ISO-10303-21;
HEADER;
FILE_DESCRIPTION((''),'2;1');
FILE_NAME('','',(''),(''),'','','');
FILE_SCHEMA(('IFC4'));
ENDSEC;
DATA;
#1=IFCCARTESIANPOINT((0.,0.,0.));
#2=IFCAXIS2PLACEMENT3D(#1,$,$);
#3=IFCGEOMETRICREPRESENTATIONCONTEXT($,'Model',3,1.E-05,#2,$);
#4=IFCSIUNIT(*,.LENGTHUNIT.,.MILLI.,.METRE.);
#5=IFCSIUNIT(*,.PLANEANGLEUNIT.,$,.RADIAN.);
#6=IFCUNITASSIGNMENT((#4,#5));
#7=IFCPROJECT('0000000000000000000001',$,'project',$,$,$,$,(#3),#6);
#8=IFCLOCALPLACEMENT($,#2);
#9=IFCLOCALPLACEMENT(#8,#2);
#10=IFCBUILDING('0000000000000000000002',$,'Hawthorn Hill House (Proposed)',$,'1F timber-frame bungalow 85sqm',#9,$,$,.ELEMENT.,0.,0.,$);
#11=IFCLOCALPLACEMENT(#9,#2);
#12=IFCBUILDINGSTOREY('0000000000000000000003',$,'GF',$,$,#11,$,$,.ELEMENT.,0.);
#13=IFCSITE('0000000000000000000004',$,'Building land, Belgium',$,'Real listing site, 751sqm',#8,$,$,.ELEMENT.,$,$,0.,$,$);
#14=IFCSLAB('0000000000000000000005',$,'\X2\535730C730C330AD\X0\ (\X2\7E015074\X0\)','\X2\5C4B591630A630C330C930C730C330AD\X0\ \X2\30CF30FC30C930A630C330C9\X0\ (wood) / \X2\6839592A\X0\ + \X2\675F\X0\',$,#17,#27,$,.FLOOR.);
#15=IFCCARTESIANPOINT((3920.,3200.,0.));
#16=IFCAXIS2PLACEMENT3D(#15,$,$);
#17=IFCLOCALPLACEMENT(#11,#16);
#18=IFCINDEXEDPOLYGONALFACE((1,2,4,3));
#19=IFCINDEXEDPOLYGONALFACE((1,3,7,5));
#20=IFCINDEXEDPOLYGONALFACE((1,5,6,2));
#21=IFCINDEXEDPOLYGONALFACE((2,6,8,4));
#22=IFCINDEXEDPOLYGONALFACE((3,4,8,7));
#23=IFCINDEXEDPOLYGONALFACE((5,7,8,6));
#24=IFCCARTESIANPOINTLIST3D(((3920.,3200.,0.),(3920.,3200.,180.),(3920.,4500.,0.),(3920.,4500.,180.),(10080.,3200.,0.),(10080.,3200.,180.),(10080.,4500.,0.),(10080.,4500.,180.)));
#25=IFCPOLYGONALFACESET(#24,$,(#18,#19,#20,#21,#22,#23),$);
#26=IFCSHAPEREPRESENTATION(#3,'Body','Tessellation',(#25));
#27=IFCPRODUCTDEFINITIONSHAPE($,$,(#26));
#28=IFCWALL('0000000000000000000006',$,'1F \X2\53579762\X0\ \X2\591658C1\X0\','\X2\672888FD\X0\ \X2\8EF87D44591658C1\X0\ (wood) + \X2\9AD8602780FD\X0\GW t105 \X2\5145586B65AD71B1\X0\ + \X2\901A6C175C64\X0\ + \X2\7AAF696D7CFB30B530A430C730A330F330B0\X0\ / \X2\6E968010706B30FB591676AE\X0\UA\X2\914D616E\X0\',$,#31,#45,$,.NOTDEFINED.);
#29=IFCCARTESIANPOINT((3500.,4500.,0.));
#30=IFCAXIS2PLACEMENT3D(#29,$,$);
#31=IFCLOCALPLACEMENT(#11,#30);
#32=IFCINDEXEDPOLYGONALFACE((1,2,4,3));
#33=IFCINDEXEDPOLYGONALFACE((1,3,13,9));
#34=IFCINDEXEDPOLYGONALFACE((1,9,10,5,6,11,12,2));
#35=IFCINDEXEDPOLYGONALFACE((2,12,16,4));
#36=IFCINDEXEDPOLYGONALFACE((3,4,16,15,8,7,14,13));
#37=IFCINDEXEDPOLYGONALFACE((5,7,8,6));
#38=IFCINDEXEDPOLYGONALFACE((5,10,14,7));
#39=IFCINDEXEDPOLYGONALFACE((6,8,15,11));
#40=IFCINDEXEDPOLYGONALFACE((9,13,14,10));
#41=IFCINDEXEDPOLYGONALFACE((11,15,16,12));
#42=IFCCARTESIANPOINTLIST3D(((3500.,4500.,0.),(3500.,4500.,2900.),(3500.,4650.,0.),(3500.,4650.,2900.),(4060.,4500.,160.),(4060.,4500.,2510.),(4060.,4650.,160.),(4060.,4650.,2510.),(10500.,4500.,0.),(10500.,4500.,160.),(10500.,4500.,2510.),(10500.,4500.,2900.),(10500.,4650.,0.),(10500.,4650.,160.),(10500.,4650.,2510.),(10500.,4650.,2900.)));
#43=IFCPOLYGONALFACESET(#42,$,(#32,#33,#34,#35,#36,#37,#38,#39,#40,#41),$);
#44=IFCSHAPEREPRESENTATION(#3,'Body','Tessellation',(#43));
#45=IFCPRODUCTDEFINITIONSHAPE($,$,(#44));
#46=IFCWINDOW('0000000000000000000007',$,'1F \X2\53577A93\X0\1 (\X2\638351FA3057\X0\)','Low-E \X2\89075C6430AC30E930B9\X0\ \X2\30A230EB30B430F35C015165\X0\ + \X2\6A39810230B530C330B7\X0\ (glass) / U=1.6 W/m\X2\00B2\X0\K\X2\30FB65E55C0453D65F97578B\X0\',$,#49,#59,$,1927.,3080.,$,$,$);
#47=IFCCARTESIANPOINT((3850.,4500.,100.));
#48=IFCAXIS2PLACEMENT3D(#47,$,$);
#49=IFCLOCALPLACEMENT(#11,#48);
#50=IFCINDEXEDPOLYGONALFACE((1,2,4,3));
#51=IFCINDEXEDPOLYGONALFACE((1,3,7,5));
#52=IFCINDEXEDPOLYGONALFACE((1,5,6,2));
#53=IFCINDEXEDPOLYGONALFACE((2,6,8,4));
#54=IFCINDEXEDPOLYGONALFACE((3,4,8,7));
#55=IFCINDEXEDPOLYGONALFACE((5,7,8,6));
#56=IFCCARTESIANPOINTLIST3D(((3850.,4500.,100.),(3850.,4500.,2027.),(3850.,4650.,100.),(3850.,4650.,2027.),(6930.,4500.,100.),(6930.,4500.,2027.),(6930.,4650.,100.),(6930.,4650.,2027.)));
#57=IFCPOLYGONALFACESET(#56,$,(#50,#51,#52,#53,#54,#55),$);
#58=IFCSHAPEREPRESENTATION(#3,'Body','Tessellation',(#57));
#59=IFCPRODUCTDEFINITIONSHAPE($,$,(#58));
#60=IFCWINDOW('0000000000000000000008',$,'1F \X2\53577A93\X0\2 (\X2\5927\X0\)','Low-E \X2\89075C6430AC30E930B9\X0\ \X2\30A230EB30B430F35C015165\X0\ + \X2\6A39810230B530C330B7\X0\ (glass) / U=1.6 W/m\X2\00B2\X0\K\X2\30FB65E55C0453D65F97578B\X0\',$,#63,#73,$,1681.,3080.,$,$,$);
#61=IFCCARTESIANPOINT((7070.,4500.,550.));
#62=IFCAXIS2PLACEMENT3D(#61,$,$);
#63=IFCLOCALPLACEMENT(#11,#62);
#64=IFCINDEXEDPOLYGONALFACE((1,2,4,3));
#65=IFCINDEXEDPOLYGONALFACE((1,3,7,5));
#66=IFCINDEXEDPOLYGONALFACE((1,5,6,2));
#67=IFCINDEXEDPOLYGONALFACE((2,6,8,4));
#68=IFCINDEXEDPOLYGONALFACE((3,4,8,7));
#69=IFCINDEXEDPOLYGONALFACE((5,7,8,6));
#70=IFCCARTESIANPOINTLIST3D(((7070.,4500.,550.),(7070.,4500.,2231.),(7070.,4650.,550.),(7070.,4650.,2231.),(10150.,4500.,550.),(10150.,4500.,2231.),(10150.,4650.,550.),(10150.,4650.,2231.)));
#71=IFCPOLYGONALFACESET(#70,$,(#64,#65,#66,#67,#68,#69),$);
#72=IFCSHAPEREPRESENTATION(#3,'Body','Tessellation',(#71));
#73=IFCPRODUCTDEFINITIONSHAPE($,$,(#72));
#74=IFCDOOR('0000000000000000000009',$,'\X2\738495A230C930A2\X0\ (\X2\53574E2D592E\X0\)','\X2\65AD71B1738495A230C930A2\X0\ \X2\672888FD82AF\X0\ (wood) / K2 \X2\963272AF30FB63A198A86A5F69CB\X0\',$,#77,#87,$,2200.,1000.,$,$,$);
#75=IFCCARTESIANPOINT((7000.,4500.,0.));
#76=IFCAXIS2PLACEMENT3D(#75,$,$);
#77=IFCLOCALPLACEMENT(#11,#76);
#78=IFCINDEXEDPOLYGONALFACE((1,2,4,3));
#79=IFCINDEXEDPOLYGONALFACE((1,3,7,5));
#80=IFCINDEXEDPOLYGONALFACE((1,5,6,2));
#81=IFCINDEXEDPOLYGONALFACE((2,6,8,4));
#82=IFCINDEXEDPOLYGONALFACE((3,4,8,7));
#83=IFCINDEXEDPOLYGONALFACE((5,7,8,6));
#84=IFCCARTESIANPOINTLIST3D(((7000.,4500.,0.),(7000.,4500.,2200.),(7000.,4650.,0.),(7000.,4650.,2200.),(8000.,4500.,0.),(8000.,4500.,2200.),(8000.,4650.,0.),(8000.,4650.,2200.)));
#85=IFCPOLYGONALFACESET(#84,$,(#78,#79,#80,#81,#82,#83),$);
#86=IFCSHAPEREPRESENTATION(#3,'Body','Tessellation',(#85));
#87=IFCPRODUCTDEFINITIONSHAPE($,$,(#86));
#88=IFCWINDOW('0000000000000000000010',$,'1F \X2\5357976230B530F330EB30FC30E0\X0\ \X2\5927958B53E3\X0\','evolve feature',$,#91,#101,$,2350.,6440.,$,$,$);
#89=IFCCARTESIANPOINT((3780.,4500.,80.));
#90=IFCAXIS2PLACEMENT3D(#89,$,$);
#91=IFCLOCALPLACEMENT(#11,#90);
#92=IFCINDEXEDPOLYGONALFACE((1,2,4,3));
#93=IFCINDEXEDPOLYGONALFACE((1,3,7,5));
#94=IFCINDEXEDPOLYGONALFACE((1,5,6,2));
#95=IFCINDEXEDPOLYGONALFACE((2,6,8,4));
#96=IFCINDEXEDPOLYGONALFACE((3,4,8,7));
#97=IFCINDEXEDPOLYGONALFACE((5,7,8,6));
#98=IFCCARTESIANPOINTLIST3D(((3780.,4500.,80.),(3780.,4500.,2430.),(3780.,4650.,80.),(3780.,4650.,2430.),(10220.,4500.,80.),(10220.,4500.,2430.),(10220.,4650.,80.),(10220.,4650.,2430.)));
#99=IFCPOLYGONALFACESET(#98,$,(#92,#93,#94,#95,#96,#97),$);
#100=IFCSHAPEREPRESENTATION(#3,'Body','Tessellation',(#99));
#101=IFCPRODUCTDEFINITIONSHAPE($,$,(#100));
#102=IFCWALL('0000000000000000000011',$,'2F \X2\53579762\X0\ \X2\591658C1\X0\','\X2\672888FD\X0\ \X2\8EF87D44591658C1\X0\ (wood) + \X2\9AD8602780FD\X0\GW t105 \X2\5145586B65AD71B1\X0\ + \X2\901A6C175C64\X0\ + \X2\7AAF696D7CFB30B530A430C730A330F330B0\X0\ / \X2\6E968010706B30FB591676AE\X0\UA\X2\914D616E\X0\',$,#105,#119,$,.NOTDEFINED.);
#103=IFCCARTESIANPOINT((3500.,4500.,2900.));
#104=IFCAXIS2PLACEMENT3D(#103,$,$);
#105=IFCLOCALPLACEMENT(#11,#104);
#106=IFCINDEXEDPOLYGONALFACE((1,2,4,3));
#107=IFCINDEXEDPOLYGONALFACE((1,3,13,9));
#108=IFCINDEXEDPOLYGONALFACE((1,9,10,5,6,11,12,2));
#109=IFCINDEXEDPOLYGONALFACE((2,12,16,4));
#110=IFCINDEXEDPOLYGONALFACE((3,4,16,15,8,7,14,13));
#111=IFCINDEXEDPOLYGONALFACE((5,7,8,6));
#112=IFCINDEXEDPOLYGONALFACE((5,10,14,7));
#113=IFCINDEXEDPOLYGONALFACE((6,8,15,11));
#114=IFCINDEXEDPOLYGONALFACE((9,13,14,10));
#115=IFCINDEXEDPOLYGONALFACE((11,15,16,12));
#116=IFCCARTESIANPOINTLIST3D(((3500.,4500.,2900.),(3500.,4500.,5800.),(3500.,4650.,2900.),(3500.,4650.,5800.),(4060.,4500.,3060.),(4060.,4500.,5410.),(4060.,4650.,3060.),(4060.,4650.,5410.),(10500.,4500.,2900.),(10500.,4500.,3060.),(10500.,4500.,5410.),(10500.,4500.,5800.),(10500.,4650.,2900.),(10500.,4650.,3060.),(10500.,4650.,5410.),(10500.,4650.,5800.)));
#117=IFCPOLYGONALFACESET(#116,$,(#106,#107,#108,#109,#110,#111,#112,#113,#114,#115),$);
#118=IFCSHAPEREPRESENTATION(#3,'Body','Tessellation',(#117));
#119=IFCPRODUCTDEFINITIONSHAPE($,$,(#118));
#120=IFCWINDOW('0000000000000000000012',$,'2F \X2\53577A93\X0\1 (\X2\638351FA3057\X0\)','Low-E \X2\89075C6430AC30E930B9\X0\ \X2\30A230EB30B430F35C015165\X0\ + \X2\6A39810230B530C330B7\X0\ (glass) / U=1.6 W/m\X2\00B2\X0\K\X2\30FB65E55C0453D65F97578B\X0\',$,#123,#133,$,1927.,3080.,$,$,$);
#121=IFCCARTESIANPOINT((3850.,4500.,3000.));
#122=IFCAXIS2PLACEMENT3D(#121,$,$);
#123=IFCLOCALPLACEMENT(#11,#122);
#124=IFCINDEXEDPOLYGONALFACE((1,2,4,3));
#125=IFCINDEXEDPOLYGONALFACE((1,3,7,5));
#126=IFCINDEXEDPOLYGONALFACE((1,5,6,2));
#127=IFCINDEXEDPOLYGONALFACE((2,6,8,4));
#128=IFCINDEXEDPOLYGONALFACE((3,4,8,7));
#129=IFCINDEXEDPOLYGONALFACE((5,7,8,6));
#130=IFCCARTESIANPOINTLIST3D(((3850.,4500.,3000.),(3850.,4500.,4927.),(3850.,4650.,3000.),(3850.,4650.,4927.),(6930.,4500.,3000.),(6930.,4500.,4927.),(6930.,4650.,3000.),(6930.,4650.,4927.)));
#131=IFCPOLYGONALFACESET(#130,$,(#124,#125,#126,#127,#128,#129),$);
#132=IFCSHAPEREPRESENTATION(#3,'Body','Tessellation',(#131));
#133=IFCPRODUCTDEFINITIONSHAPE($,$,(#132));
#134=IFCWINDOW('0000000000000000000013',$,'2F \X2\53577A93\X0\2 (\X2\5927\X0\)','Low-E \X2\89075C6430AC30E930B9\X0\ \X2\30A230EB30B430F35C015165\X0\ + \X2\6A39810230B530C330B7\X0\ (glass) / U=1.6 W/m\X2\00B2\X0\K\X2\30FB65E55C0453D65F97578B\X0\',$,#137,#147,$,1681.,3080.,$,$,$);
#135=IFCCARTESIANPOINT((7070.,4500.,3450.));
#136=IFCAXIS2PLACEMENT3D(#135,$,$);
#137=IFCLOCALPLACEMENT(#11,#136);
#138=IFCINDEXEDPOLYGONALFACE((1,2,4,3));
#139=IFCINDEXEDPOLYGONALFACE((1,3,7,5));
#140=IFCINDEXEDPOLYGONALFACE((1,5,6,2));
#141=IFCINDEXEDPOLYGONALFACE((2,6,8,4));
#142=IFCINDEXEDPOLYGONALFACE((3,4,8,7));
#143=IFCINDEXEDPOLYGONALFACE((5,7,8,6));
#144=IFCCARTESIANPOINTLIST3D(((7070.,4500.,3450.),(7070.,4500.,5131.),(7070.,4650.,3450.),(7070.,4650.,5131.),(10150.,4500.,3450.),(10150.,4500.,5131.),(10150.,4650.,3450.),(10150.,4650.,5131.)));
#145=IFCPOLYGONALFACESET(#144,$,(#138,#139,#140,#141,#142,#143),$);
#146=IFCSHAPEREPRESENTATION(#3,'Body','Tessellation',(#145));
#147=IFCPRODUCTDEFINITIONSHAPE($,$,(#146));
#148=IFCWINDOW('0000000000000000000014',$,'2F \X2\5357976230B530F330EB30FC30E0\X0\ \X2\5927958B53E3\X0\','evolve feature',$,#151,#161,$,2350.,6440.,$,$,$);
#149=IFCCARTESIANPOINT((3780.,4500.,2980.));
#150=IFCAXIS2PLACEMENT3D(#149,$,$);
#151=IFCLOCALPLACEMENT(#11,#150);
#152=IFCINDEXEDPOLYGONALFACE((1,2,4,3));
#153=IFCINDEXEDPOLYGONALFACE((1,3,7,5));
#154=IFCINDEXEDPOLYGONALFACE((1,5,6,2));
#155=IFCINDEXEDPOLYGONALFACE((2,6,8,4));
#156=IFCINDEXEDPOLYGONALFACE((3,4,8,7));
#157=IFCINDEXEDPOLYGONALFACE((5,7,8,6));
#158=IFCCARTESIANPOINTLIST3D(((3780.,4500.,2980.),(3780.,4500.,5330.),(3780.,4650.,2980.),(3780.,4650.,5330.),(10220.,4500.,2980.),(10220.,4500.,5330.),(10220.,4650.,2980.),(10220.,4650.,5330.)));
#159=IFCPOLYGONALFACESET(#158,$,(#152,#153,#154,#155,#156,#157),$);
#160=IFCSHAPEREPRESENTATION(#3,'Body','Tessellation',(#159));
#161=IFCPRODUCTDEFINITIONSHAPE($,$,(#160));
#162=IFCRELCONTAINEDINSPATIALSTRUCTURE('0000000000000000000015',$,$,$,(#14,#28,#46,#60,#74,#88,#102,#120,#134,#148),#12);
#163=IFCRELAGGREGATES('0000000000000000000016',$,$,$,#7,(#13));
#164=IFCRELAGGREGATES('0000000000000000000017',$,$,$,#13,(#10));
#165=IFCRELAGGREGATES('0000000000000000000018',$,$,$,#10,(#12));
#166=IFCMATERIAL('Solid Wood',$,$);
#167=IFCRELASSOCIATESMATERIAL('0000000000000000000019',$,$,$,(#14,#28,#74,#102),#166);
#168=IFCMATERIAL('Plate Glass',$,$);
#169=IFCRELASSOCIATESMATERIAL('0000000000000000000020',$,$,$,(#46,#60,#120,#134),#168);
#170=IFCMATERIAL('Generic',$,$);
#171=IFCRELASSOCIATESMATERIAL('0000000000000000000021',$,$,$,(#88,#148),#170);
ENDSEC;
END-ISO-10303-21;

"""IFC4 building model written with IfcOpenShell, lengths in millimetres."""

from ifc_helpers import new_model, si_unit, frame, frame_2d, origin, place, context, project, spatial, rectangle, extrude, material, element, fill, save


model = new_model("IFC4")

# Units and contexts
model_context = context("Model", 3, precision=1e-05, world=origin())
ifc_project = project(units=[si_unit("LENGTHUNIT", "METRE", prefix="MILLI"), si_unit("PLANEANGLEUNIT", "RADIAN")], contexts=[model_context])

# Site, building, storey
site_placement = place(None, origin())
site = spatial("IfcSite", under=ifc_project, at=site_placement, Name="Building land, Belgium", ObjectType="Real listing site, 751sqm", CompositionType="ELEMENT", RefElevation=0.0)
building_placement = place(site_placement, origin())
building = spatial("IfcBuilding", under=site, at=building_placement, Name="Hawthorn Hill House (Proposed)", ObjectType="1F timber-frame bungalow 85sqm", CompositionType="ELEMENT", ElevationOfRefHeight=0.0, ElevationOfTerrain=0.0)
storey_placement = place(building_placement, origin())
storey = spatial("IfcBuildingStorey", under=building, at=storey_placement, Name="GF", CompositionType="ELEMENT", Elevation=0.0)

# Slab
ifc_material_1 = material(Name="Solid Wood")
slab_1_placement = place(storey_placement, frame((3920.0, 3200.0, 0.0)))
element("IfcSlab", 1, at=slab_1_placement, inside=storey, material=ifc_material_1, Name="南デッキ (縁側)", Description="屋外ウッドデッキ ハードウッド (wood) / 根太 + 束", PredefinedType="FLOOR", context=model_context, shape_type="SweptSolid", body=[
    extrude(rectangle(XDim=6160.0, YDim=1300.0, at=frame_2d((3080.0, 650.0))), frame((3920.0, 3200.0, 0.0)), (0.0, 0.0, 1.0), 180.0),
])
ifc_material_2 = material(Name="Generic")

# Wall, openings, windows, door
wall_1_placement = place(storey_placement, frame((3500.0, 4500.0, 0.0)))
wall_1 = element("IfcWall", 2, at=wall_1_placement, inside=storey, material=ifc_material_1, Name="1F 南面 外壁", Description="木製 軸組外壁 (wood) + 高性能GW t105 充填断熱 + 通気層 + 窯業系サイディング / 準耐火・外皮UA配慮", PredefinedType="NOTDEFINED", context=model_context, shape_type="SweptSolid", body=[
    extrude(rectangle(XDim=7000.0, YDim=150.0, at=frame_2d((3500.0, 75.0))), frame((3500.0, 4500.0, 0.0)), (0.0, 0.0, 1.0), 2900.0),
])
opening_1_placement = place(storey_placement, frame((3850.0, 4500.0, 100.0)))
opening_1 = element("IfcOpeningElement", 3, at=opening_1_placement, cuts=wall_1, PredefinedType="NOTDEFINED", context=model_context, shape_type="SweptSolid", body=[
    extrude(rectangle(XDim=3080.0, YDim=150.0, at=frame_2d((1540.0, 75.0))), frame((3850.0, 4500.0, 100.0)), (0.0, 0.0, 1.0), 1927.0),
])
opening_2_placement = place(storey_placement, frame((7070.0, 4500.0, 550.0)))
opening_2 = element("IfcOpeningElement", 4, at=opening_2_placement, cuts=wall_1, PredefinedType="NOTDEFINED", context=model_context, shape_type="SweptSolid", body=[
    extrude(rectangle(XDim=3080.0, YDim=150.0, at=frame_2d((1540.0, 75.0))), frame((7070.0, 4500.0, 550.0)), (0.0, 0.0, 1.0), 1681.0),
])
opening_3_placement = place(storey_placement, frame((7000.0, 4500.0, 0.0)))
opening_3 = element("IfcOpeningElement", 5, at=opening_3_placement, cuts=wall_1, PredefinedType="NOTDEFINED", context=model_context, shape_type="SweptSolid", body=[
    extrude(rectangle(XDim=1000.0, YDim=150.0, at=frame_2d((500.0, 75.0))), frame((7000.0, 4500.0, 0.0)), (0.0, 0.0, 1.0), 2200.0),
])
opening_4_placement = place(storey_placement, frame((3780.0, 4500.0, 80.0)))
opening_4 = element("IfcOpeningElement", 6, at=opening_4_placement, cuts=wall_1, PredefinedType="NOTDEFINED", context=model_context, shape_type="SweptSolid", body=[
    extrude(rectangle(XDim=6440.0, YDim=150.0, at=frame_2d((3220.0, 75.0))), frame((3780.0, 4500.0, 80.0)), (0.0, 0.0, 1.0), 2350.0),
])
ifc_material_3 = material(Name="Plate Glass")
window_1_placement = place(storey_placement, frame((3850.0, 4500.0, 100.0)))
window_1 = element("IfcWindow", 7, at=window_1_placement, inside=storey, material=ifc_material_3, Name="1F 南窓1 (掃出し)", Description="Low-E 複層ガラス アルゴン封入 + 樹脂サッシ (glass) / U=1.6 W/m²K・日射取得型", OverallHeight=1927.0, OverallWidth=3080.0, context=model_context, shape_type="SweptSolid", body=[
    extrude(rectangle(XDim=3080.0, YDim=150.0, at=frame_2d((1540.0, 75.0))), frame((3850.0, 4500.0, 100.0)), (0.0, 0.0, 1.0), 1927.0),
])
fill(opening_1, window_1)
window_2_placement = place(storey_placement, frame((7070.0, 4500.0, 550.0)))
window_2 = element("IfcWindow", 8, at=window_2_placement, inside=storey, material=ifc_material_3, Name="1F 南窓2 (大)", Description="Low-E 複層ガラス アルゴン封入 + 樹脂サッシ (glass) / U=1.6 W/m²K・日射取得型", OverallHeight=1681.0, OverallWidth=3080.0, context=model_context, shape_type="SweptSolid", body=[
    extrude(rectangle(XDim=3080.0, YDim=150.0, at=frame_2d((1540.0, 75.0))), frame((7070.0, 4500.0, 550.0)), (0.0, 0.0, 1.0), 1681.0),
])
fill(opening_2, window_2)
door_placement = place(storey_placement, frame((7000.0, 4500.0, 0.0)))
door = element("IfcDoor", 9, at=door_placement, inside=storey, material=ifc_material_1, Name="玄関ドア (南中央)", Description="断熱玄関ドア 木製芯 (wood) / K2 防犯・採風機構", OverallHeight=2200.0, OverallWidth=1000.0, context=model_context, shape_type="SweptSolid", body=[
    extrude(rectangle(XDim=1000.0, YDim=150.0, at=frame_2d((500.0, 75.0))), frame((7000.0, 4500.0, 0.0)), (0.0, 0.0, 1.0), 2200.0),
])
fill(opening_3, door)
window_3_placement = place(storey_placement, frame((3780.0, 4500.0, 80.0)))
window_3 = element("IfcWindow", 10, at=window_3_placement, inside=storey, material=ifc_material_2, Name="1F 南面サンルーム 大開口", Description="evolve feature", OverallHeight=2350.0, OverallWidth=6440.0, context=model_context, shape_type="SweptSolid", body=[
    extrude(rectangle(XDim=6440.0, YDim=150.0, at=frame_2d((3220.0, 75.0))), frame((3780.0, 4500.0, 80.0)), (0.0, 0.0, 1.0), 2350.0),
])
fill(opening_4, window_3)

# Wall, openings, windows
wall_2_placement = place(storey_placement, frame((3500.0, 4500.0, 2900.0)))
wall_2 = element("IfcWall", 11, at=wall_2_placement, inside=storey, material=ifc_material_1, Name="2F 南面 外壁", Description="木製 軸組外壁 (wood) + 高性能GW t105 充填断熱 + 通気層 + 窯業系サイディング / 準耐火・外皮UA配慮", PredefinedType="NOTDEFINED", context=model_context, shape_type="SweptSolid", body=[
    extrude(rectangle(XDim=7000.0, YDim=150.0, at=frame_2d((3500.0, 75.0))), frame((3500.0, 4500.0, 2900.0)), (0.0, 0.0, 1.0), 2900.0),
])
opening_5_placement = place(storey_placement, frame((3850.0, 4500.0, 3000.0)))
opening_5 = element("IfcOpeningElement", 12, at=opening_5_placement, cuts=wall_2, PredefinedType="NOTDEFINED", context=model_context, shape_type="SweptSolid", body=[
    extrude(rectangle(XDim=3080.0, YDim=150.0, at=frame_2d((1540.0, 75.0))), frame((3850.0, 4500.0, 3000.0)), (0.0, 0.0, 1.0), 1927.0),
])
opening_6_placement = place(storey_placement, frame((7070.0, 4500.0, 3450.0)))
opening_6 = element("IfcOpeningElement", 13, at=opening_6_placement, cuts=wall_2, PredefinedType="NOTDEFINED", context=model_context, shape_type="SweptSolid", body=[
    extrude(rectangle(XDim=3080.0, YDim=150.0, at=frame_2d((1540.0, 75.0))), frame((7070.0, 4500.0, 3450.0)), (0.0, 0.0, 1.0), 1681.0),
])
opening_7_placement = place(storey_placement, frame((3780.0, 4500.0, 2980.0)))
opening_7 = element("IfcOpeningElement", 14, at=opening_7_placement, cuts=wall_2, PredefinedType="NOTDEFINED", context=model_context, shape_type="SweptSolid", body=[
    extrude(rectangle(XDim=6440.0, YDim=150.0, at=frame_2d((3220.0, 75.0))), frame((3780.0, 4500.0, 2980.0)), (0.0, 0.0, 1.0), 2350.0),
])
window_4_placement = place(storey_placement, frame((3850.0, 4500.0, 3000.0)))
window_4 = element("IfcWindow", 15, at=window_4_placement, inside=storey, material=ifc_material_3, Name="2F 南窓1 (掃出し)", Description="Low-E 複層ガラス アルゴン封入 + 樹脂サッシ (glass) / U=1.6 W/m²K・日射取得型", OverallHeight=1927.0, OverallWidth=3080.0, context=model_context, shape_type="SweptSolid", body=[
    extrude(rectangle(XDim=3080.0, YDim=150.0, at=frame_2d((1540.0, 75.0))), frame((3850.0, 4500.0, 3000.0)), (0.0, 0.0, 1.0), 1927.0),
])
fill(opening_5, window_4)
window_5_placement = place(storey_placement, frame((7070.0, 4500.0, 3450.0)))
window_5 = element("IfcWindow", 16, at=window_5_placement, inside=storey, material=ifc_material_3, Name="2F 南窓2 (大)", Description="Low-E 複層ガラス アルゴン封入 + 樹脂サッシ (glass) / U=1.6 W/m²K・日射取得型", OverallHeight=1681.0, OverallWidth=3080.0, context=model_context, shape_type="SweptSolid", body=[
    extrude(rectangle(XDim=3080.0, YDim=150.0, at=frame_2d((1540.0, 75.0))), frame((7070.0, 4500.0, 3450.0)), (0.0, 0.0, 1.0), 1681.0),
])
fill(opening_6, window_5)
window_6_placement = place(storey_placement, frame((3780.0, 4500.0, 2980.0)))
window_6 = element("IfcWindow", 17, at=window_6_placement, inside=storey, material=ifc_material_2, Name="2F 南面サンルーム 大開口", Description="evolve feature", OverallHeight=2350.0, OverallWidth=6440.0, context=model_context, shape_type="SweptSolid", body=[
    extrude(rectangle(XDim=6440.0, YDim=150.0, at=frame_2d((3220.0, 75.0))), frame((3780.0, 4500.0, 2980.0)), (0.0, 0.0, 1.0), 2350.0),
])
fill(opening_7, window_6)

save(model, "model.ifc")
